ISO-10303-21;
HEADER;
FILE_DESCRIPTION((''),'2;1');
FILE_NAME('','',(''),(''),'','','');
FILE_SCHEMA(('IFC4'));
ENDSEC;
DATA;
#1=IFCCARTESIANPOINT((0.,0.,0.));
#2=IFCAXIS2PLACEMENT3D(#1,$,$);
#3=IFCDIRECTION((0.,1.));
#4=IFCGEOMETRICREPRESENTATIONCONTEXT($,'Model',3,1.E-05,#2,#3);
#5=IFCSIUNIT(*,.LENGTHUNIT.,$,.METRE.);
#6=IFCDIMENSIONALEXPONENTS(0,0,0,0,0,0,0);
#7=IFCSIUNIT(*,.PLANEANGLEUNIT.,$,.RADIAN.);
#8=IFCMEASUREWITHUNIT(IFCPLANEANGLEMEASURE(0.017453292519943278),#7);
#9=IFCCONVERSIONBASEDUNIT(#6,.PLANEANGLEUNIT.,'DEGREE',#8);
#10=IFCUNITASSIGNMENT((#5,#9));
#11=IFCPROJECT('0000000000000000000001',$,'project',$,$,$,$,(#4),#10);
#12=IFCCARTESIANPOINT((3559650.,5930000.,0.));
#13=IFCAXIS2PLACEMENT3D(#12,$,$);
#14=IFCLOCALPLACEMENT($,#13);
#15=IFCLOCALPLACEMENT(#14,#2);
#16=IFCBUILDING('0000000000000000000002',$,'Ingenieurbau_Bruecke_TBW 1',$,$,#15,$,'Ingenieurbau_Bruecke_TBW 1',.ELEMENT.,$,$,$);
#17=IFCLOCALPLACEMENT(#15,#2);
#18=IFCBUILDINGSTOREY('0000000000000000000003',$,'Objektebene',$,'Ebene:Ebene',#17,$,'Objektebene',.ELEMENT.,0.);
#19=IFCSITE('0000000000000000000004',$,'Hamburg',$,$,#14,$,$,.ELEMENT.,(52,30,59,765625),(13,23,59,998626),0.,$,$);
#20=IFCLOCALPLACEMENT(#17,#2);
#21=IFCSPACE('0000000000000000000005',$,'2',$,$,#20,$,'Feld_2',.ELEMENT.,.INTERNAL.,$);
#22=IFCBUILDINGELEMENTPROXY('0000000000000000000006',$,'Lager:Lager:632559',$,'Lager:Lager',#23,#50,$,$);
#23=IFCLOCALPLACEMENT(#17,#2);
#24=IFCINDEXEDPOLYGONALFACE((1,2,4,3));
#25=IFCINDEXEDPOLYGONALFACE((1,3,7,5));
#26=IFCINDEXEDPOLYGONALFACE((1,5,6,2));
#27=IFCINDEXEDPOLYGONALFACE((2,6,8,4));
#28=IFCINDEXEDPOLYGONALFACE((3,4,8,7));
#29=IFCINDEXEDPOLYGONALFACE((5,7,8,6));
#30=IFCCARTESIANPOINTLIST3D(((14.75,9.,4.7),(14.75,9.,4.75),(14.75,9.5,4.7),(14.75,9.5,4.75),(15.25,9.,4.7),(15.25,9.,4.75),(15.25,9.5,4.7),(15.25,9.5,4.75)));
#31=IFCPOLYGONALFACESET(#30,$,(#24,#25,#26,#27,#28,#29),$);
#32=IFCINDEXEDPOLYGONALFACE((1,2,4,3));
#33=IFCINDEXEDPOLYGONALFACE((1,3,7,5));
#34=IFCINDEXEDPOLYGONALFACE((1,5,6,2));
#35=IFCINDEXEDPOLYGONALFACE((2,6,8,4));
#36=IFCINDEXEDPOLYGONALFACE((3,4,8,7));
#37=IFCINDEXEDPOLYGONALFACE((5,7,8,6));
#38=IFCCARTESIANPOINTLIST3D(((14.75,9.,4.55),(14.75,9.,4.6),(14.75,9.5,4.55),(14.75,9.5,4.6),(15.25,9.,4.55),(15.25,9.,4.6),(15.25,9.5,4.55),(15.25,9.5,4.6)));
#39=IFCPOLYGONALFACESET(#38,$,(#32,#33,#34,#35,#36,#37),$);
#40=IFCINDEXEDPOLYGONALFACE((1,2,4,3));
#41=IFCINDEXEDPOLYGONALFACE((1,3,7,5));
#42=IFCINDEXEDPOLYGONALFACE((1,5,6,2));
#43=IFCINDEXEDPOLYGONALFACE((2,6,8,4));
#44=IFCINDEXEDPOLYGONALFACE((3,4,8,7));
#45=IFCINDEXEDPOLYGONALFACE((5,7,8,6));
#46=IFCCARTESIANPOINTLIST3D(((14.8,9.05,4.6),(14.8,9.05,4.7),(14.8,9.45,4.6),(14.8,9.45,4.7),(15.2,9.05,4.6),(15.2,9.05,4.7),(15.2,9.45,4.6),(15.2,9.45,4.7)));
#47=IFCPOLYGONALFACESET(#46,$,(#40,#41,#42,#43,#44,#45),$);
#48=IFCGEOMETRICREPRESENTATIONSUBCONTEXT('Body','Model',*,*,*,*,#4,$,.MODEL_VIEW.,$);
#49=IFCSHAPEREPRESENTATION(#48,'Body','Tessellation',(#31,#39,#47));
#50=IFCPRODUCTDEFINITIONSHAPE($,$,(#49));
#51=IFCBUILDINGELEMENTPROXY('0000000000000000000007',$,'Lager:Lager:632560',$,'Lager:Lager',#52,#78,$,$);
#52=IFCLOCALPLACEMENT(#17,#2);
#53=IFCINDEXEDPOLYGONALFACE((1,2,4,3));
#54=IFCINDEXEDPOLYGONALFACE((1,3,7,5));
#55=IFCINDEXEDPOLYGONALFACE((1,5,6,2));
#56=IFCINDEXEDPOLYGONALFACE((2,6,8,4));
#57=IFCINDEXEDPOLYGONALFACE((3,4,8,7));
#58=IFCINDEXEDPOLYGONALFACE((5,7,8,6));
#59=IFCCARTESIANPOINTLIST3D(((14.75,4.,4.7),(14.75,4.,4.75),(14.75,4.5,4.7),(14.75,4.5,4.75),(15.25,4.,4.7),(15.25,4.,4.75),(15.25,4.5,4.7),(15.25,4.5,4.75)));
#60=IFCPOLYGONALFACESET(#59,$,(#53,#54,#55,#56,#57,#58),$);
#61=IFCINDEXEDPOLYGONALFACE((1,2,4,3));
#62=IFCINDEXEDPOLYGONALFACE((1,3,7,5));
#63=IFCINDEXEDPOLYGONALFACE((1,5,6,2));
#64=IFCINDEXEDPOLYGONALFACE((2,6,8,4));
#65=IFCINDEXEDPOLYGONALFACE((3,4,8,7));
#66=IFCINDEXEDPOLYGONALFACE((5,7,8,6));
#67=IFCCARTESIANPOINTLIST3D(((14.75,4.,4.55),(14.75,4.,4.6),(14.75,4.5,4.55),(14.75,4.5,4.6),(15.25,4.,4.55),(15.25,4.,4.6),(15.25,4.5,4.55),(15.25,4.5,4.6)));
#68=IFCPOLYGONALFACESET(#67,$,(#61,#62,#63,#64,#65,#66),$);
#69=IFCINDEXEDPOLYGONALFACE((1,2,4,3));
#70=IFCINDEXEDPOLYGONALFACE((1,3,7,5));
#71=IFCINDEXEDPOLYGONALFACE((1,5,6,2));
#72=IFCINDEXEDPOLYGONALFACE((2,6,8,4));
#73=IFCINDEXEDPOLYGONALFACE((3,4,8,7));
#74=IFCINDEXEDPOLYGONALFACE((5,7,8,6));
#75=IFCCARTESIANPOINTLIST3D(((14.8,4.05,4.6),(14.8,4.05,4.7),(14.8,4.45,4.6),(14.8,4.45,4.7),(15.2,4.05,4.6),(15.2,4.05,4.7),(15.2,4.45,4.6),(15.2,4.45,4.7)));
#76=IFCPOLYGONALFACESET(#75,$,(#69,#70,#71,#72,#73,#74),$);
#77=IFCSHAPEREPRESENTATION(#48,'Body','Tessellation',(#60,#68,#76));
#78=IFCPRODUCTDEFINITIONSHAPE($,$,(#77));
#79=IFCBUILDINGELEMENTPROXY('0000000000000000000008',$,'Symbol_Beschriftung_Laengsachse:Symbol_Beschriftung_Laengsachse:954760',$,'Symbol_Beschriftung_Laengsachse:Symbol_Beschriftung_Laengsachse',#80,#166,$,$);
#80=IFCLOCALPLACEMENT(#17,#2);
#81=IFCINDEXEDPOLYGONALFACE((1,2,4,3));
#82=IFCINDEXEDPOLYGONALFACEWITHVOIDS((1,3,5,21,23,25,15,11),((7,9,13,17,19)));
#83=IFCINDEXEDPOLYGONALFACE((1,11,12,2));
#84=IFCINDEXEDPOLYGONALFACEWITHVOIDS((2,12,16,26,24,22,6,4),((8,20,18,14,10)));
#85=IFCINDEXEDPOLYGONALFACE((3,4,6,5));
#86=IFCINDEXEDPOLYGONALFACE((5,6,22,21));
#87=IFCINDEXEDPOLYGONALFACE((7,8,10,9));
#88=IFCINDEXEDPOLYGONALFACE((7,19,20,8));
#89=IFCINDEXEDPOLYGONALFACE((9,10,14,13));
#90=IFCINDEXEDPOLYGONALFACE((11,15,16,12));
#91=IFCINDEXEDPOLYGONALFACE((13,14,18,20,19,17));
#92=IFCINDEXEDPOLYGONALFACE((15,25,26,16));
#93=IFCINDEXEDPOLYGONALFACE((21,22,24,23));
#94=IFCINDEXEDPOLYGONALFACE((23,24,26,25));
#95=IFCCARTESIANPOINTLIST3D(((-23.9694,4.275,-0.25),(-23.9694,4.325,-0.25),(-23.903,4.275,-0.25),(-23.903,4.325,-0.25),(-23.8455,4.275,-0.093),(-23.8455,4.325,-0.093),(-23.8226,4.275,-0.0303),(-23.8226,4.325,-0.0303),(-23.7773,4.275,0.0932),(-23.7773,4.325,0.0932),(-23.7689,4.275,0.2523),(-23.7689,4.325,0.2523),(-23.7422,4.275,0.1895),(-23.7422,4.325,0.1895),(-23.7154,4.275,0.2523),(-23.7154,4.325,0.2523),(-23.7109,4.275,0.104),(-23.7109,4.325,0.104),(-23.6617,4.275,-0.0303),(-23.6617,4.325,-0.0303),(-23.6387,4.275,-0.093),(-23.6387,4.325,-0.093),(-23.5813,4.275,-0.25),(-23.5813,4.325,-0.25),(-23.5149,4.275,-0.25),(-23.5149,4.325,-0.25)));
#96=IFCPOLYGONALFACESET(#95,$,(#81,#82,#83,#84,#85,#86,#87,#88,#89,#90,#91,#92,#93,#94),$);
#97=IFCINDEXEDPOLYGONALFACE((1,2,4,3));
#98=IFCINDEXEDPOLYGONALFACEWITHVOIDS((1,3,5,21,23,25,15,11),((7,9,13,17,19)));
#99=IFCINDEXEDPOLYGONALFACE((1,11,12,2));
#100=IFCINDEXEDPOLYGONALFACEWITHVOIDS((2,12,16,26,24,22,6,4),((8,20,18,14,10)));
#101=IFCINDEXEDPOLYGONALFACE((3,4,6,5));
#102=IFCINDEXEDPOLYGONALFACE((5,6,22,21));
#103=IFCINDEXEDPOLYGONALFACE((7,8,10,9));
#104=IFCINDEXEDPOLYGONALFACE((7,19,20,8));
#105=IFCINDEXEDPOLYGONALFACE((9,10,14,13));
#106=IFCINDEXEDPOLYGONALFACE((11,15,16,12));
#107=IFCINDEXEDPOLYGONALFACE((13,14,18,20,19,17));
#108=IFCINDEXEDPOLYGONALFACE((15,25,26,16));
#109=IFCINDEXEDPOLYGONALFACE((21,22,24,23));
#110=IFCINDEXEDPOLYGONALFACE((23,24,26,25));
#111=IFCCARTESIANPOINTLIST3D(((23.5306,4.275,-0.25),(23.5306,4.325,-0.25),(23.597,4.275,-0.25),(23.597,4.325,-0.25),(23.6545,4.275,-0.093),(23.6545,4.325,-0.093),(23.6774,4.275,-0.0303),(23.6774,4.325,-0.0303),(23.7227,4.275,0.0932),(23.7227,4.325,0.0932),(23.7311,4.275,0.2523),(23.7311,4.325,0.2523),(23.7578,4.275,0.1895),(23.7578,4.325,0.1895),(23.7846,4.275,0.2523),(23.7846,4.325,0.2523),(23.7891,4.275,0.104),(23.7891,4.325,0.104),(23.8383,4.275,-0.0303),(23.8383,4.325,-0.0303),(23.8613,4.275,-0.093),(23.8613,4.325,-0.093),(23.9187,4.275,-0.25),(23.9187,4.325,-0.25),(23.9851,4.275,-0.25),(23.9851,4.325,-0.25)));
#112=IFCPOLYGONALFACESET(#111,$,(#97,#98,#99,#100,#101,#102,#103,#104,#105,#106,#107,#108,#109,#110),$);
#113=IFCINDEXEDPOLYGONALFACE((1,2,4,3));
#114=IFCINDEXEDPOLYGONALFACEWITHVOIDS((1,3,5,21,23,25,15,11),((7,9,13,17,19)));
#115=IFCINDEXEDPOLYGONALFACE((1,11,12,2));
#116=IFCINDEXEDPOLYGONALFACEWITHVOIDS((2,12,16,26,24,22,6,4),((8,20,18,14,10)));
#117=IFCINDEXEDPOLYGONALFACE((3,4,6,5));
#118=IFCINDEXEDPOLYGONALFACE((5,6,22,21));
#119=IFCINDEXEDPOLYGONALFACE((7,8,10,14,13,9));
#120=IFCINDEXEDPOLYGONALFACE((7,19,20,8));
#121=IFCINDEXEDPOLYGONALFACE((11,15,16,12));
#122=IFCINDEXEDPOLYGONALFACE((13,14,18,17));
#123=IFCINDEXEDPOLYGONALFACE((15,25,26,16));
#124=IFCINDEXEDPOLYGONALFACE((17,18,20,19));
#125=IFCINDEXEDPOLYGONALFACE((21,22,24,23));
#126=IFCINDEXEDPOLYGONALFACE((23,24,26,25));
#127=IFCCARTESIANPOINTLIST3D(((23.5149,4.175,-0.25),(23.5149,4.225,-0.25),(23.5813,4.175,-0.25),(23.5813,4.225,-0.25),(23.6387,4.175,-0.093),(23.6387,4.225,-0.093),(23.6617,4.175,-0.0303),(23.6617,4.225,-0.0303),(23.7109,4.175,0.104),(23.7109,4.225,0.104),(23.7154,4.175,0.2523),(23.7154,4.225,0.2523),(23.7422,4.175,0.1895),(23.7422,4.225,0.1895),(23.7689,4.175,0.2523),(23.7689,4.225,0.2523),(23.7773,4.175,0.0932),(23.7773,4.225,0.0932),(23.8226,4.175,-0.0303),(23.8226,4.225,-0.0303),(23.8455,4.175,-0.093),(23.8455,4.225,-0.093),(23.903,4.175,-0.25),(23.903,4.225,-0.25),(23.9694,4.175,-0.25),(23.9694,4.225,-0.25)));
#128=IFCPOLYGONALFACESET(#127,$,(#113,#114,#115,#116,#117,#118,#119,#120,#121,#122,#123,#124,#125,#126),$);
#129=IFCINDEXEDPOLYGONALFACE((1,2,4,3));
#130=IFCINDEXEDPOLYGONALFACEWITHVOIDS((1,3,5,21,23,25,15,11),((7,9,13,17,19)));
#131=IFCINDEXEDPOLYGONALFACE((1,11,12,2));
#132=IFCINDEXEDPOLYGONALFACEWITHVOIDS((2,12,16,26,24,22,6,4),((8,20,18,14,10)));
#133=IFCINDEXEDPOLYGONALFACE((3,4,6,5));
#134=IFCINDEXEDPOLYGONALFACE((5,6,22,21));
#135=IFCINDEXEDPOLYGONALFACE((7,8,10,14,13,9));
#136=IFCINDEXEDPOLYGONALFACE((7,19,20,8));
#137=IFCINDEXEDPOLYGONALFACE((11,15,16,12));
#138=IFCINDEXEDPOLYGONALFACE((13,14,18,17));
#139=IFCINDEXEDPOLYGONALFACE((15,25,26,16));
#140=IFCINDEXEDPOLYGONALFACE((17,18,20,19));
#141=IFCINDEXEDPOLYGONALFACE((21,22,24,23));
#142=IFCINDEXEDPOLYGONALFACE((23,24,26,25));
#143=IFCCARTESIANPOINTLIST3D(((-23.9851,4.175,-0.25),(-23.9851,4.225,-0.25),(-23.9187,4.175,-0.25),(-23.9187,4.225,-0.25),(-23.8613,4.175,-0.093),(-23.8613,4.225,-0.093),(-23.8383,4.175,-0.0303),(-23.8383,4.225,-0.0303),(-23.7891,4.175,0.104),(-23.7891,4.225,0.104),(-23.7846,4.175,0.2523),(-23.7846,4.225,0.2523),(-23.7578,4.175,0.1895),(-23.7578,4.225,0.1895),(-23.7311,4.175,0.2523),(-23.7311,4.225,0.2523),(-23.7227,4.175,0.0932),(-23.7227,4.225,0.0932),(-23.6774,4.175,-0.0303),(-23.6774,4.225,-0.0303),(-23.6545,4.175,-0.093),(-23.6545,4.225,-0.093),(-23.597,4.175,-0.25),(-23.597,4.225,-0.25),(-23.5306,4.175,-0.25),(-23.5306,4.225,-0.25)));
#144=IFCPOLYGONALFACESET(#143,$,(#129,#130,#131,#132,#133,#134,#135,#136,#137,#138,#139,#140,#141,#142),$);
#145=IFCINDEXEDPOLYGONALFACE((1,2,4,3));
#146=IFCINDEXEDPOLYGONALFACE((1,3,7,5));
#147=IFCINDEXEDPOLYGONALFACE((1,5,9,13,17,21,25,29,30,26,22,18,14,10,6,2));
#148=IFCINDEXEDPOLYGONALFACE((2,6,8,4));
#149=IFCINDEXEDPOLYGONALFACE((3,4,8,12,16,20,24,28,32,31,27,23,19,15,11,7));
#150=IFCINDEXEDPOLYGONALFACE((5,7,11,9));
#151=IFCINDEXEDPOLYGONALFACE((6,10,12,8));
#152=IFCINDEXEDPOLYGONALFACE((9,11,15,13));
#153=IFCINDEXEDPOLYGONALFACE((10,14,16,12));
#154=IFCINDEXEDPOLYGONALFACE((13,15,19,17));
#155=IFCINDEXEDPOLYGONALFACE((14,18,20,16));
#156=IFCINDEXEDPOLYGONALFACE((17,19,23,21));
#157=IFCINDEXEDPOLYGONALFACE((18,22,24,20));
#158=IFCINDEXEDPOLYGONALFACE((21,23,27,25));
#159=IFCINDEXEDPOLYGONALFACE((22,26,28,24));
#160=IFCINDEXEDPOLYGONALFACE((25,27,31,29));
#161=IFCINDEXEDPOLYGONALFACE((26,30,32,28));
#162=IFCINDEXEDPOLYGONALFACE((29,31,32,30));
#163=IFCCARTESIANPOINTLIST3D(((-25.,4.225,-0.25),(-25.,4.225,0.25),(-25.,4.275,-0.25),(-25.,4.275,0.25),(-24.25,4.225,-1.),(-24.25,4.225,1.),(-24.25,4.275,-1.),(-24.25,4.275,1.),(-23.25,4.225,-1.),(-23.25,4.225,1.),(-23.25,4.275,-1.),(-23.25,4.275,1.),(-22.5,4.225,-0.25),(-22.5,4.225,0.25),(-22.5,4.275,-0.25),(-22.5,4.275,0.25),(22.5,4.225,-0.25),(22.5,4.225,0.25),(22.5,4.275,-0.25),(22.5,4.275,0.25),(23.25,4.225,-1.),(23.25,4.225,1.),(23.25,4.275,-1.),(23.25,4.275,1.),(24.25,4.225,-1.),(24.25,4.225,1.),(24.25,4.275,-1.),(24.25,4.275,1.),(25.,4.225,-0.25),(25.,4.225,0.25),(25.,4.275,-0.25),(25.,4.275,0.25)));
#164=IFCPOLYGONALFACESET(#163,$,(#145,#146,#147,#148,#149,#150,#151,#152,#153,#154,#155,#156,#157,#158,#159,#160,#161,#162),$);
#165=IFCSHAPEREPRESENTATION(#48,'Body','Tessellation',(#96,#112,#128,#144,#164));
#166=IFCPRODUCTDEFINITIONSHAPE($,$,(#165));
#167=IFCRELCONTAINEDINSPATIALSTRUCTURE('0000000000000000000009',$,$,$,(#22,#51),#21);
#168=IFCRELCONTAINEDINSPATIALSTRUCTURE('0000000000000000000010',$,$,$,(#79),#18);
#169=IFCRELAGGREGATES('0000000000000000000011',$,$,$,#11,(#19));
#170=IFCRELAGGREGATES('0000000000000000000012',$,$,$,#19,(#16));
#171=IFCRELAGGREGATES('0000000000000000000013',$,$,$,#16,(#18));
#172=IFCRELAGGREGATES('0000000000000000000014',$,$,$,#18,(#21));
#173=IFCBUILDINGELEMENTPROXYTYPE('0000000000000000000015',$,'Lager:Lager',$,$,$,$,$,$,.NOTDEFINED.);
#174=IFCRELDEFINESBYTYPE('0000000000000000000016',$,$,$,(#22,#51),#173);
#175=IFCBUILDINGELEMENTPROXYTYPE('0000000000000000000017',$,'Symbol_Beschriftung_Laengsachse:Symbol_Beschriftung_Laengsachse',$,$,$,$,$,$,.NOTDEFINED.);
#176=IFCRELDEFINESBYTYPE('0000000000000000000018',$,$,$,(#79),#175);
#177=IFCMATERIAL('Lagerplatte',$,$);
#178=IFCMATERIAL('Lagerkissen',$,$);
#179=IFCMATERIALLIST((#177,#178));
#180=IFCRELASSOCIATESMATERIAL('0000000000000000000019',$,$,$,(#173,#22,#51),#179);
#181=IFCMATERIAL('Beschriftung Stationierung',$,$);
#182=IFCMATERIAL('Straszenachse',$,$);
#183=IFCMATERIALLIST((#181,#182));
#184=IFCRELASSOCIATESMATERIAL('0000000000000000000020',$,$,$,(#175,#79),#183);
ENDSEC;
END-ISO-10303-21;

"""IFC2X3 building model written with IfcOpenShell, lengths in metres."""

from ifc_helpers import new_model, entity, si_unit, converted_unit, direction, frame, origin, origin_2d_with_axis, place, context, subcontext, project, spatial, polyline, rectangle, outline, extrude, source, transform, mapped, material, material_list, type_object, type_shapes, element, save


model = new_model("IFC2X3")

# Units and contexts
model_context = context("Model", 3, precision=1e-05, world=origin(), true_north=direction((0.0, 1.0)))
body_context = subcontext(model_context, "Body", "Model", "MODEL_VIEW")
ifc_project = project(units=[si_unit("LENGTHUNIT", "METRE"), converted_unit("PLANEANGLEUNIT", "DEGREE", entity("IfcPlaneAngleMeasure", 0.017453292519943278), si_unit("PLANEANGLEUNIT", "RADIAN"), dimensions=[0, 0, 0, 0, 0, 0, 0])], contexts=[model_context])

# Site, building, storey
site_placement = place(None, frame((3559650.0, 5930000.0, 0.0)))
site = spatial("IfcSite", under=ifc_project, at=site_placement, Name="Hamburg", CompositionType="ELEMENT", RefLatitude=(52, 30, 59, 765625), RefLongitude=(13, 23, 59, 998626), RefElevation=0.0)
building_placement = place(site_placement, origin())
building = spatial("IfcBuilding", under=site, at=building_placement, Name="Ingenieurbau_Bruecke_TBW 1", LongName="Ingenieurbau_Bruecke_TBW 1", CompositionType="ELEMENT")
storey_placement = place(building_placement, origin())
storey = spatial("IfcBuildingStorey", under=building, at=storey_placement, Name="Objektebene", ObjectType="Ebene:Ebene", LongName="Objektebene", CompositionType="ELEMENT", Elevation=0.0)

# Shared definitions
space_1_placement = place(storey_placement, origin())
space_1 = spatial("IfcSpace", under=storey, at=space_1_placement, Name="2", LongName="Feld_2", CompositionType="ELEMENT", InteriorOrExteriorSpace="INTERNAL")

# Building element proxies
ifc_material_1 = material(Name="Lagerplatte")
ifc_material_2 = material(Name="Lagerkissen")
ifc_material_list_1 = material_list([ifc_material_1, ifc_material_2])
building_element_proxy_type_1 = type_object("IfcBuildingElementProxyType", Name="Lager:Lager", PredefinedType="NOTDEFINED", material=ifc_material_list_1)
shared_shape_1 = source(origin(), body_context, "Body", "SweptSolid", [
    extrude(rectangle(XDim=0.5, YDim=0.5, at=origin_2d_with_axis()), frame((0.0, 0.0, 4.7), z_axis=(0.0, 0.0, 1.0), x_axis=(0.0, 1.0, 0.0)), (0.0, 0.0, 1.0), 0.05),
    extrude(rectangle(XDim=0.5, YDim=0.5, at=origin_2d_with_axis()), frame((0.0, 0.0, 4.55), z_axis=(0.0, 0.0, 1.0), x_axis=(0.0, 1.0, 0.0)), (0.0, 0.0, 1.0), 0.05),
    extrude(rectangle(XDim=0.4, YDim=0.4, at=origin_2d_with_axis()), frame((0.0, 0.0, 4.6), z_axis=(0.0, 0.0, 1.0), x_axis=(0.0, 1.0, 0.0)), (0.0, 0.0, 1.0), 0.1),
])
type_shapes(building_element_proxy_type_1, [shared_shape_1])
for number, where, name in (
    (1, (15.0, 9.25, 0.0), "Lager:Lager:632559"),
    (2, (15.0, 4.25, 0.0), "Lager:Lager:632560"),
):
    element("IfcBuildingElementProxy", number, at=place(space_1_placement, frame(where)), inside=space_1, type_object=building_element_proxy_type_1, material=ifc_material_list_1, Name=name, ObjectType="Lager:Lager", context=body_context, shape_type="MappedRepresentation", body=[
        mapped(shared_shape_1, transform((0.0, 0.0, 0.0), scale=1.0)),
    ])
ifc_material_3 = material(Name="Beschriftung Stationierung")
ifc_material_4 = material(Name="Straszenachse")
ifc_material_list_2 = material_list([ifc_material_3, ifc_material_4])
building_element_proxy_type_2 = type_object("IfcBuildingElementProxyType", Name="Symbol_Beschriftung_Laengsachse:Symbol_Beschriftung_Laengsachse", PredefinedType="NOTDEFINED", material=ifc_material_list_2)
shared_shape_2 = source(origin(), body_context, "Body", "SweptSolid", [
    extrude(outline(polyline([(-0.2272, -0.1648), (-0.1609, -0.1648), (-0.1035, -0.0078), (0.1034, -0.0078), (0.1609, -0.1648), (0.2272, -0.1648), (0.0267, 0.3375), (-0.0267, 0.3375), (-0.2272, -0.1648)]), holes=[polyline([(-0.0804, 0.0549), (-0.0313, 0.1892), (0.0, 0.2747), (0.0352, 0.1784), (0.0805, 0.0549), (-0.0804, 0.0549)])]), frame((-23.7421, 0.025, -0.0852), z_axis=(0.0, 1.0, 0.0), x_axis=(-1.0, 0.0, 0.0)), (0.0, 0.0, 1.0), 0.05),
    extrude(outline(polyline([(-0.2272, -0.1648), (-0.1609, -0.1648), (-0.1035, -0.0078), (0.1034, -0.0078), (0.1609, -0.1648), (0.2272, -0.1648), (0.0267, 0.3375), (-0.0267, 0.3375), (-0.2272, -0.1648)]), holes=[polyline([(-0.0804, 0.0549), (-0.0313, 0.1892), (0.0, 0.2747), (0.0352, 0.1784), (0.0805, 0.0549), (-0.0804, 0.0549)])]), frame((23.7579, 0.025, -0.0852), z_axis=(0.0, 1.0, 0.0), x_axis=(-1.0, 0.0, 0.0)), (0.0, 0.0, 1.0), 0.05),
    extrude(outline(polyline([(-0.2373, -0.1499), (0.3035, -0.1499), (0.3233, -0.1003), (-0.0688, 0.2722), (-0.0934, 0.2105), (0.031, 0.0989), (-0.0457, -0.0932), (-0.2127, -0.0883), (-0.2373, -0.1499)]), holes=[polyline([(0.0212, -0.0951), (0.0809, 0.0544), (0.1788, -0.0334), (0.2551, -0.1018), (0.1641, -0.0992), (0.0212, -0.0951)])]), frame((23.7421, -0.075, -0.0852), z_axis=(0.0, 1.0, 0.0), x_axis=(0.370726, 0.0, 0.928742)), (0.0, 0.0, 1.0), 0.05),
    extrude(outline(polyline([(-0.2373, -0.1499), (0.3035, -0.1499), (0.3233, -0.1003), (-0.0688, 0.2722), (-0.0934, 0.2105), (0.031, 0.0989), (-0.0457, -0.0932), (-0.2127, -0.0883), (-0.2373, -0.1499)]), holes=[polyline([(0.0212, -0.0951), (0.0809, 0.0544), (0.1788, -0.0334), (0.2551, -0.1018), (0.1641, -0.0992), (0.0212, -0.0951)])]), frame((-23.7579, -0.075, -0.0852), z_axis=(0.0, 1.0, 0.0), x_axis=(0.370726, 0.0, 0.928742)), (0.0, 0.0, 1.0), 0.05),
    extrude(outline(polyline([(-17.5009, -17.8544), (-16.4402, -17.8544), (-15.7331, -17.1473), (-15.7331, -16.0867), (16.0867, 15.7331), (17.1473, 15.7331), (17.8544, 16.4402), (17.8544, 17.5009), (17.5009, 17.8544), (16.4402, 17.8544), (15.7331, 17.1473), (15.7331, 16.0867), (-16.0867, -15.7331), (-17.1473, -15.7331), (-17.8544, -16.4402), (-17.8544, -17.5009), (-17.5009, -17.8544)])), frame((0.0, -0.025, 0.0), z_axis=(0.0, 1.0, 0.0), x_axis=(0.707107, 0.0, 0.707107)), (0.0, 0.0, 1.0), 0.05),
])
type_shapes(building_element_proxy_type_2, [shared_shape_2])
proxy_1_placement = place(storey_placement, frame((0.0, 4.25, 0.0)))
element("IfcBuildingElementProxy", 3, at=proxy_1_placement, inside=storey, type_object=building_element_proxy_type_2, material=ifc_material_list_2, Name="Symbol_Beschriftung_Laengsachse:Symbol_Beschriftung_Laengsachse:954760", ObjectType="Symbol_Beschriftung_Laengsachse:Symbol_Beschriftung_Laengsachse", context=body_context, shape_type="MappedRepresentation", body=[
    mapped(shared_shape_2, transform((0.0, 0.0, 0.0), scale=1.0)),
])

save(model, "model.ifc")
